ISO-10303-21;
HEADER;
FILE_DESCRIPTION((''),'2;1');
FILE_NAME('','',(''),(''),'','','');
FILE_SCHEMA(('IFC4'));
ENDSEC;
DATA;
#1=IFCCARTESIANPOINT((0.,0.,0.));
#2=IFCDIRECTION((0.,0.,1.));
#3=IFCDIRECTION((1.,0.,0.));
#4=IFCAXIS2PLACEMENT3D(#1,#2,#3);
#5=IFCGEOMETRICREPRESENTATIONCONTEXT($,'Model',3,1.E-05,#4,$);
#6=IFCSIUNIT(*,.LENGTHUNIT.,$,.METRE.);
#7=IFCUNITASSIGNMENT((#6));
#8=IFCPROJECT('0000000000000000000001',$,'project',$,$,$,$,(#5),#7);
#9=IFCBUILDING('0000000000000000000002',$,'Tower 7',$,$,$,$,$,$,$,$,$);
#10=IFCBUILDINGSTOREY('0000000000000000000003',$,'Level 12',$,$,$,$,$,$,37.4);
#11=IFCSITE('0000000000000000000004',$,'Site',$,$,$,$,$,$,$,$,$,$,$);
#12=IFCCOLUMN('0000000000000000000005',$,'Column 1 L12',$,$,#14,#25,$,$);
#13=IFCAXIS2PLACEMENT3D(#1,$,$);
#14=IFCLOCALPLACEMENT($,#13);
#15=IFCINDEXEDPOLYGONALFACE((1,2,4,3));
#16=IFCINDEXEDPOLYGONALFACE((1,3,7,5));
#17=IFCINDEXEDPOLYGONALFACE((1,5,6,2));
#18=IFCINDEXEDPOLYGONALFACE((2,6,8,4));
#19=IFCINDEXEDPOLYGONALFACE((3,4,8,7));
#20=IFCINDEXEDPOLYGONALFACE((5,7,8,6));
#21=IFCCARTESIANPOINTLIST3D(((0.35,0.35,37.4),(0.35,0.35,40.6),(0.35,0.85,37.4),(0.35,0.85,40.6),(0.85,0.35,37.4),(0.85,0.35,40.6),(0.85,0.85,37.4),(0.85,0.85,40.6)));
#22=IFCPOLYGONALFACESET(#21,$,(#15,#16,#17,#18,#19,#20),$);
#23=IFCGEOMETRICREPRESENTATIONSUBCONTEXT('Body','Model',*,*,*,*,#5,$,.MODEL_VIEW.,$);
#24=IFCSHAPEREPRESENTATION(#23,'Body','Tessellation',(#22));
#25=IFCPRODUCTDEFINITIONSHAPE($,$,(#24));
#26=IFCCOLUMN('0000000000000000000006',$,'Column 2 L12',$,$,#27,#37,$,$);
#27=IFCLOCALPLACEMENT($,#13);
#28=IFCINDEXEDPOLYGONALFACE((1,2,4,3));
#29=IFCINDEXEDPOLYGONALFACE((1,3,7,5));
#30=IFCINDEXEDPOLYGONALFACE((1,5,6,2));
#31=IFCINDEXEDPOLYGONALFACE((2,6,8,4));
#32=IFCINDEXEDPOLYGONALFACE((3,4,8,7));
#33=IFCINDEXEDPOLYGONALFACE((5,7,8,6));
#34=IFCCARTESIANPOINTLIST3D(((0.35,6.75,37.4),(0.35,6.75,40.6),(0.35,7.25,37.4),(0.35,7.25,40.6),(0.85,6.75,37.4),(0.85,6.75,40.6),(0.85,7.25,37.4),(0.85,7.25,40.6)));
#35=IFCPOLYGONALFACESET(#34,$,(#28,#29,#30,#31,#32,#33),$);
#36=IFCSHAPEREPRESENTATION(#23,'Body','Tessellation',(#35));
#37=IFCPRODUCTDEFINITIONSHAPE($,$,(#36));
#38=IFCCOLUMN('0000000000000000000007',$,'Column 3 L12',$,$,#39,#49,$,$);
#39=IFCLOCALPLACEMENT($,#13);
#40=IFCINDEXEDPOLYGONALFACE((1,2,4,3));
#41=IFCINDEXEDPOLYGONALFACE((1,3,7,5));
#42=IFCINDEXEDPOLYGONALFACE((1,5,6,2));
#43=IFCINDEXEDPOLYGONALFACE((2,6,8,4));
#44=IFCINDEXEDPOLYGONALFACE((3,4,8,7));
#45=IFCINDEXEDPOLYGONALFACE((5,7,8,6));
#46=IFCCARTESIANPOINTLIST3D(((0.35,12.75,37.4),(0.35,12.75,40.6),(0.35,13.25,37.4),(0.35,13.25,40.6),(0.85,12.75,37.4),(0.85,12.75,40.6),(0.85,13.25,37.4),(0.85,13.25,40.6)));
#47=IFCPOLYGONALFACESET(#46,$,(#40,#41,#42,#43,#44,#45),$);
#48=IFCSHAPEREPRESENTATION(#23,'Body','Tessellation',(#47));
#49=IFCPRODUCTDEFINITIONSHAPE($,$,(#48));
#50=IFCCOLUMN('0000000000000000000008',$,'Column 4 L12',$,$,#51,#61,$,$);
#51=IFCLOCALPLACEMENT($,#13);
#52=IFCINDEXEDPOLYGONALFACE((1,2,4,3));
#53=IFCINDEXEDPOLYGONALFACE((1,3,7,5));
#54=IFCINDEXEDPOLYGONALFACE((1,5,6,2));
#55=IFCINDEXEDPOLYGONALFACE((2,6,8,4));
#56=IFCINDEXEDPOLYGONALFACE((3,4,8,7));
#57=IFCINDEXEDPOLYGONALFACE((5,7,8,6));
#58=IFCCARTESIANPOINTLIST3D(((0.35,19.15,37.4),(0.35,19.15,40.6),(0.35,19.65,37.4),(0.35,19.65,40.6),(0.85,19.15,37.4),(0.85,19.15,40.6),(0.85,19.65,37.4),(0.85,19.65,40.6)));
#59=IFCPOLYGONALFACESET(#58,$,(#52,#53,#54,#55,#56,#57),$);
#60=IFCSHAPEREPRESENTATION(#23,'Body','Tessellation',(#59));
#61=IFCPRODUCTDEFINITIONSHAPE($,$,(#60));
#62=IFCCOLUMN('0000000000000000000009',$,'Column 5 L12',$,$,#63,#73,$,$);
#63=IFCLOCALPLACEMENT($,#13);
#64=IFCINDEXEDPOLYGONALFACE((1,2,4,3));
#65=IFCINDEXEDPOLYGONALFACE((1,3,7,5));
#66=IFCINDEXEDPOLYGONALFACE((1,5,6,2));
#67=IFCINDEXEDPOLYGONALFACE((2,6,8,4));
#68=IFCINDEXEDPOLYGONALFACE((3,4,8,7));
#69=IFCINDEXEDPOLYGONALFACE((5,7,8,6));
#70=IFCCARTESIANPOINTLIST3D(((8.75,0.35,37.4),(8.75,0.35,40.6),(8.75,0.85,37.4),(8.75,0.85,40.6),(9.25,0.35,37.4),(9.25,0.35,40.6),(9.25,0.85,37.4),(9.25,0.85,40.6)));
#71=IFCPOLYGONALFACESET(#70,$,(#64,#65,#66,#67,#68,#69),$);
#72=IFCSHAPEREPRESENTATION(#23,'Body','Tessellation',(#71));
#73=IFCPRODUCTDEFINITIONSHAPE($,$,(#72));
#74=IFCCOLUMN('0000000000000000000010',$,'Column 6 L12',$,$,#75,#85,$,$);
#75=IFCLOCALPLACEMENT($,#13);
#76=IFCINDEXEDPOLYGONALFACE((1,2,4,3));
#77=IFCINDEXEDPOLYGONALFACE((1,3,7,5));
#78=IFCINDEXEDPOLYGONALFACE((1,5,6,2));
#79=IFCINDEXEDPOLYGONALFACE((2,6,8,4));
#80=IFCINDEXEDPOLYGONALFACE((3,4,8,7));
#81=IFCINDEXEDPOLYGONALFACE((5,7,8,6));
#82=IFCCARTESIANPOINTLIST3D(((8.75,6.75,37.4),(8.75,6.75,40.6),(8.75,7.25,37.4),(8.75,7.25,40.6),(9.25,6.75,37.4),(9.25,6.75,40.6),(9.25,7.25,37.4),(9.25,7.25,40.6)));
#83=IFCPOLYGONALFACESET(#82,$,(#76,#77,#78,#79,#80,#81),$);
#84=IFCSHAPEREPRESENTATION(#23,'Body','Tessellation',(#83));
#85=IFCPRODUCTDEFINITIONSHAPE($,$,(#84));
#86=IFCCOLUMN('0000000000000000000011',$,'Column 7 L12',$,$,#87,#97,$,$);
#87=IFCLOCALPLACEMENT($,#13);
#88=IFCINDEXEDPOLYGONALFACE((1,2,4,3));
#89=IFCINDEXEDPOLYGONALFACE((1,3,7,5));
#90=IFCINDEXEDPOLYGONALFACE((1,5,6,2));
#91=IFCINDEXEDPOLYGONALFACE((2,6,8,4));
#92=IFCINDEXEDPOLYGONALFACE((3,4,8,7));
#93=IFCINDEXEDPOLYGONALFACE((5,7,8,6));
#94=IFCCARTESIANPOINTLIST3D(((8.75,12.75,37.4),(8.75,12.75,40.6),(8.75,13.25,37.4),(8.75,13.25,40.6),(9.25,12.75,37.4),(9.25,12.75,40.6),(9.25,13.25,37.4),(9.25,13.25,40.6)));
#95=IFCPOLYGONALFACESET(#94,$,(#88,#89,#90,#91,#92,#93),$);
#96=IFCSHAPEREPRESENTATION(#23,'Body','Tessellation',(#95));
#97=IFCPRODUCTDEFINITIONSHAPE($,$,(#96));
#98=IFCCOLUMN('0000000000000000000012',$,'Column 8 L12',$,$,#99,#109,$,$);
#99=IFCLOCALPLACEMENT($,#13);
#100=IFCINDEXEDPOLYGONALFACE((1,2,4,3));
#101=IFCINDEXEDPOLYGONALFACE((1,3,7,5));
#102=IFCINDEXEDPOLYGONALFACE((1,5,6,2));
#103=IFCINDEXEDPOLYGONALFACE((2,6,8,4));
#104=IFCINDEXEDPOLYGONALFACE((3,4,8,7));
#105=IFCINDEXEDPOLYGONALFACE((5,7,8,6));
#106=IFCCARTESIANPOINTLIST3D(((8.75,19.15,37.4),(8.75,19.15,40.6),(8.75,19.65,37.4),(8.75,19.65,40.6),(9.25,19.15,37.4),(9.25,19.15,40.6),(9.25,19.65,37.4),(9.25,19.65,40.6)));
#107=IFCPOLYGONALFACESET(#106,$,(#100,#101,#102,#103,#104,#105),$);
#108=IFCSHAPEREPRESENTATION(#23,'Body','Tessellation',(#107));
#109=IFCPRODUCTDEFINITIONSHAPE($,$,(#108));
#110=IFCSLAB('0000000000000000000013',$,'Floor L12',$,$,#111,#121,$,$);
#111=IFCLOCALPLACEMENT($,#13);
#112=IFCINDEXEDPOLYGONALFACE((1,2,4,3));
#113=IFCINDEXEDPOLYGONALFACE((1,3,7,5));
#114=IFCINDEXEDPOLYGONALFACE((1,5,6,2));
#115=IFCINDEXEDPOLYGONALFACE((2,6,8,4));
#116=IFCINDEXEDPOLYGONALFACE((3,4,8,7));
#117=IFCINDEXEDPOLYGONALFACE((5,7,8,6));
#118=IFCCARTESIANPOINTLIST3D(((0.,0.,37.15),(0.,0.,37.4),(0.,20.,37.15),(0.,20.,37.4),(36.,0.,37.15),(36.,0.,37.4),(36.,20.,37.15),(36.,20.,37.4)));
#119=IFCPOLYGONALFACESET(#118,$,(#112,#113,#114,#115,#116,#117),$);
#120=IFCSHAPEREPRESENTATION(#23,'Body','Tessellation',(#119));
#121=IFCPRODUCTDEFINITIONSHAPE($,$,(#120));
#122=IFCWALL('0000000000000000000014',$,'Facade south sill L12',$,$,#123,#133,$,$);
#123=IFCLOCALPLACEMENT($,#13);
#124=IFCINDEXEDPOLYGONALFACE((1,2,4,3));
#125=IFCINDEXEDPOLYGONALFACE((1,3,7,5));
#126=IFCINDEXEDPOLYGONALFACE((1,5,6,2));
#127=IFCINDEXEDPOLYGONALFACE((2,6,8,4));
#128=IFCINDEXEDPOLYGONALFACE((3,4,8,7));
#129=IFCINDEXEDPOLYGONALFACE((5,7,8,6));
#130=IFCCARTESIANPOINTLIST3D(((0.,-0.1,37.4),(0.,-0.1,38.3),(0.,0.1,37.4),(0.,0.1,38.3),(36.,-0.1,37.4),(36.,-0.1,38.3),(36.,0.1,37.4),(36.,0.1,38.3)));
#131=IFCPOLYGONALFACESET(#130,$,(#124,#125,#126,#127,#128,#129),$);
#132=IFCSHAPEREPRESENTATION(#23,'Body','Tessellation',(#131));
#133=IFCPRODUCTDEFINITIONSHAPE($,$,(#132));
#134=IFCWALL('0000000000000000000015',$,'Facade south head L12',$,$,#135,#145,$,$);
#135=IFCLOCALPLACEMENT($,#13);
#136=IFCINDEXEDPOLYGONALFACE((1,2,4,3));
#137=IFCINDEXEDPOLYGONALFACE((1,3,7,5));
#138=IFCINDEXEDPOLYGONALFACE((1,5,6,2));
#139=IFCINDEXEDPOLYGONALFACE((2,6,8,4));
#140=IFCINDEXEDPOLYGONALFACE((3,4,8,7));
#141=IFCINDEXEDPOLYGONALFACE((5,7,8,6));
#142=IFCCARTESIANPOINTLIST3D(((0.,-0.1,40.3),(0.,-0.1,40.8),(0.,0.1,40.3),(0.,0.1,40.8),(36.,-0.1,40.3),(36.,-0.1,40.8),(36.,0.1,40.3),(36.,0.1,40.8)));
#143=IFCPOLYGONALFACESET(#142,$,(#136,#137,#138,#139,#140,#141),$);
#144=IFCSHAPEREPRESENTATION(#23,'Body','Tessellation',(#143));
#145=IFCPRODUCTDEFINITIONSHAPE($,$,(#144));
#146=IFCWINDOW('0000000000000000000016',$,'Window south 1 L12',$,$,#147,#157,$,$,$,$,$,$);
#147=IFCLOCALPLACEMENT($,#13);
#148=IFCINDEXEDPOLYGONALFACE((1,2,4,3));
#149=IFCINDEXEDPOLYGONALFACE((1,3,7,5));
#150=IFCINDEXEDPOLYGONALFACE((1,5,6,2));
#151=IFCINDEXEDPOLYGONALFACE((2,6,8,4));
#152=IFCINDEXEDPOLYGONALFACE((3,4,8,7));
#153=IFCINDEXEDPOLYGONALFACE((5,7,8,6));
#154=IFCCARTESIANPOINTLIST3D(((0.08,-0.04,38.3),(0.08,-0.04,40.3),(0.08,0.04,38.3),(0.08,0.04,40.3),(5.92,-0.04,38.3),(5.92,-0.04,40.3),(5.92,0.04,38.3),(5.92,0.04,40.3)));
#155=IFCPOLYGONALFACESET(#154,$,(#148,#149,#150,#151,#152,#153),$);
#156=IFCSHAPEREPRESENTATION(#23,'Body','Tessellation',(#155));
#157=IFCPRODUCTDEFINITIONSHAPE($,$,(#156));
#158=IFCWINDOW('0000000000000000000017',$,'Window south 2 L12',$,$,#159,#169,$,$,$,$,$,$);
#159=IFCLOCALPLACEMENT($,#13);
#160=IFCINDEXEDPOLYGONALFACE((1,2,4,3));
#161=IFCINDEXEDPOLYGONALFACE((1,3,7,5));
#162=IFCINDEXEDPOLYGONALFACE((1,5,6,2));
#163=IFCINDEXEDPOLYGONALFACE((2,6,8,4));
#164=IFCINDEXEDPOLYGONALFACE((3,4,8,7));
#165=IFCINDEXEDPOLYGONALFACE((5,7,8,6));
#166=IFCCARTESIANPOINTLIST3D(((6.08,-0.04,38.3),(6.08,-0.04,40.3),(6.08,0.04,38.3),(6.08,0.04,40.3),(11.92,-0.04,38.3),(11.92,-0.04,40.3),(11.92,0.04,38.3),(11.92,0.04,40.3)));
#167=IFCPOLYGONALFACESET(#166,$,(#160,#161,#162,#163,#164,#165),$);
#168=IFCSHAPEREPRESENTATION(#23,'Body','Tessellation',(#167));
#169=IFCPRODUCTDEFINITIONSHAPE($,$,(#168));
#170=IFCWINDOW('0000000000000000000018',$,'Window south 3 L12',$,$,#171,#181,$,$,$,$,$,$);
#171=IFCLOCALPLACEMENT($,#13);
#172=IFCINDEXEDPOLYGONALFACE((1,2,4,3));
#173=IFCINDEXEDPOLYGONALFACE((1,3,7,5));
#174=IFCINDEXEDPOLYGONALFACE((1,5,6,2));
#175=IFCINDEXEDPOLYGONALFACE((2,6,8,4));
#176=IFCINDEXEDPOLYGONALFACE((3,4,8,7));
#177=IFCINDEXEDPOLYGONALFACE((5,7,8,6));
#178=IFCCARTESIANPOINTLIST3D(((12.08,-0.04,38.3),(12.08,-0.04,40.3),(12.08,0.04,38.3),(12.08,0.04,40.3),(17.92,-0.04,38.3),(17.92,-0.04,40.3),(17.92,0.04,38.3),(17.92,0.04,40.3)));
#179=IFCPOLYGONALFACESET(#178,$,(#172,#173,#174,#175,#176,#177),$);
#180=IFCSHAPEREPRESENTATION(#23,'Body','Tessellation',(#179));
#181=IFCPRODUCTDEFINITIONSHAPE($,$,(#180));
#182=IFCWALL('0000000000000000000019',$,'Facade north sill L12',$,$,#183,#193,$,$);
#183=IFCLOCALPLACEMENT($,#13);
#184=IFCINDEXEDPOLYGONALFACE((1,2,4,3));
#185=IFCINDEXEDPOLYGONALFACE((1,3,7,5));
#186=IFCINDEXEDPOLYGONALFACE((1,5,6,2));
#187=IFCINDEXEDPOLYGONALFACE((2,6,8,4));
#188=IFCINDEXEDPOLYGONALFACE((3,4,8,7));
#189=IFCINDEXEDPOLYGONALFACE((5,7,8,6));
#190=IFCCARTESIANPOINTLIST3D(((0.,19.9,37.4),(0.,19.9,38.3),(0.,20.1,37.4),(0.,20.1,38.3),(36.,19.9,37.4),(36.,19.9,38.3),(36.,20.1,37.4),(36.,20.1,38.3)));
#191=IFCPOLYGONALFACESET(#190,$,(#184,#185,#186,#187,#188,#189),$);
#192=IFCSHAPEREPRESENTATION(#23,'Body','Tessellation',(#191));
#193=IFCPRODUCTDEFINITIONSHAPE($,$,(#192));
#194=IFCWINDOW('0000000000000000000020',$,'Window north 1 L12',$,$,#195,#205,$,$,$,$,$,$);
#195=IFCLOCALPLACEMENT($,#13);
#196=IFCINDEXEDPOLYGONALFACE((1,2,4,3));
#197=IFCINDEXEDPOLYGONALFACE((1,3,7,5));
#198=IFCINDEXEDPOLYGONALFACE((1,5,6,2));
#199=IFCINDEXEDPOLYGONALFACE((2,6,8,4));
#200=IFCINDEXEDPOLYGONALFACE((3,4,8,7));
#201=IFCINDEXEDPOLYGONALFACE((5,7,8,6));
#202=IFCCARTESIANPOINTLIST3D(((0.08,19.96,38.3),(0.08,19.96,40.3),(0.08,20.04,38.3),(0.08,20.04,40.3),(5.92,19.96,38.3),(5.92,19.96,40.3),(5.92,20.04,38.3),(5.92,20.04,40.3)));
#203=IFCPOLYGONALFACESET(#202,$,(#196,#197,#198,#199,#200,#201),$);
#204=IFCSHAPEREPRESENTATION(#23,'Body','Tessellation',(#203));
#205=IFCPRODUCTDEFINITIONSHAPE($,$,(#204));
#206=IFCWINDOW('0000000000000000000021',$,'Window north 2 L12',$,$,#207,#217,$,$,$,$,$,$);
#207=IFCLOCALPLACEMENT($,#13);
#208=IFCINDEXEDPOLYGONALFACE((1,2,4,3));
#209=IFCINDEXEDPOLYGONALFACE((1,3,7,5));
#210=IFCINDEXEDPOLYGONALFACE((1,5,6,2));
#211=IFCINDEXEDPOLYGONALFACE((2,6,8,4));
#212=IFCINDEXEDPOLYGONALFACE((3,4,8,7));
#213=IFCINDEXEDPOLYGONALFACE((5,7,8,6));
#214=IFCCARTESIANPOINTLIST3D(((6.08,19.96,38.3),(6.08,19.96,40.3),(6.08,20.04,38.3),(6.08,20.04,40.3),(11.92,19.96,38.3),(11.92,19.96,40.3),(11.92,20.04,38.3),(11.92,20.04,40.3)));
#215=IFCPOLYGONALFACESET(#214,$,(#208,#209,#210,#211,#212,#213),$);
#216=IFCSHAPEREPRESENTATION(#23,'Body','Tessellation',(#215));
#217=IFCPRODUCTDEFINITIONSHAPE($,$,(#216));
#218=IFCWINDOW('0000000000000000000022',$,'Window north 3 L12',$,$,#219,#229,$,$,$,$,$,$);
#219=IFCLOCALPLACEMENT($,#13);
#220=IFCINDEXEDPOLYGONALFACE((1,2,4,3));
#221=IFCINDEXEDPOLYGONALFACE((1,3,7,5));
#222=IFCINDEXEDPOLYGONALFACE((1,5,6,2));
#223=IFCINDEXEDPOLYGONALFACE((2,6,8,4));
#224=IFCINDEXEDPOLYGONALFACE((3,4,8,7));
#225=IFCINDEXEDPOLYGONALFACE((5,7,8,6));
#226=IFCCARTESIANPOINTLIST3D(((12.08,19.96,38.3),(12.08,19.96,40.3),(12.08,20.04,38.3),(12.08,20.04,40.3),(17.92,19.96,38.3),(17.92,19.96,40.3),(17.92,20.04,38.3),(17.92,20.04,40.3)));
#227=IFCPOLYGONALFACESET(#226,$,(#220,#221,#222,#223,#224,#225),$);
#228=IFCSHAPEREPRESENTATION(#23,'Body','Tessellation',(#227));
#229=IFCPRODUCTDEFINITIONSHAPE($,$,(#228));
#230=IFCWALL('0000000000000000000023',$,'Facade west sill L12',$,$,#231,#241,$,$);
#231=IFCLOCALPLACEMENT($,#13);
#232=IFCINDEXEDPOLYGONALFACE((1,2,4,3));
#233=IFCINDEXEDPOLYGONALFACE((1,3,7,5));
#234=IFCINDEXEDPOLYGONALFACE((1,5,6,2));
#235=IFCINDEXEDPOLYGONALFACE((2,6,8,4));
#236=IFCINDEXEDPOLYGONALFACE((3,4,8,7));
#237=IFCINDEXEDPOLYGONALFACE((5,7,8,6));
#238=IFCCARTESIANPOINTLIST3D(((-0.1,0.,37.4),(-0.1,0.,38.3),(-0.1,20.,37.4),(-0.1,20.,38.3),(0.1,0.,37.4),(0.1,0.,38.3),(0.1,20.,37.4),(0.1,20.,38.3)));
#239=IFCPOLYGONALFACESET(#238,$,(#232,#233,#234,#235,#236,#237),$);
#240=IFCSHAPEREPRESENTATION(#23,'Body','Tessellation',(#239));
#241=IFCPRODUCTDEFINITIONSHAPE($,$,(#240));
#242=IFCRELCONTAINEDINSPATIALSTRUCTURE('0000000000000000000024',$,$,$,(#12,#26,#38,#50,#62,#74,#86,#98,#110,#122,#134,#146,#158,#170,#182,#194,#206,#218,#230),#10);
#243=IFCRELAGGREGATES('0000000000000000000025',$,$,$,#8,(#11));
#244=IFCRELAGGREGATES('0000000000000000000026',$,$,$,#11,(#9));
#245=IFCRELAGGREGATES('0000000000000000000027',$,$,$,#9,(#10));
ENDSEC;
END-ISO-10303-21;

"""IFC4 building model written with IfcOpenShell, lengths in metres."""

from ifc_helpers import new_model, si_unit, frame, origin, origin_with_axes, origin_2d, place, context, subcontext, project, spatial, rectangle, extrude, element, save


model = new_model("IFC4")

# Units and contexts
model_context = context("Model", 3, precision=1e-05, world=origin_with_axes())
body_context = subcontext(model_context, "Body", "Model", "MODEL_VIEW")
ifc_project = project(units=[si_unit("LENGTHUNIT", "METRE")], contexts=[model_context])

# Site, building, storey
site = spatial("IfcSite", under=ifc_project, Name="Site")
building = spatial("IfcBuilding", under=site, Name="Tower 7")
storey = spatial("IfcBuildingStorey", under=building, Name="Level 12", Elevation=37.4)

# Columns
for number, where, z_axis, x_axis, name in (
    (1, (0.6, 0.6, 37.4), (0.0, 0.0, 1.0), (1.0, 0.0, 0.0), "Column 1 L12"),
    (2, (0.6, 7.0, 37.4), (0.0, 0.0, 1.0), (1.0, 0.0, 0.0), "Column 2 L12"),
    (3, (0.6, 13.0, 37.4), (0.0, 0.0, 1.0), (1.0, 0.0, 0.0), "Column 3 L12"),
    (4, (0.6, 19.4, 37.4), (0.0, 0.0, 1.0), (1.0, 0.0, 0.0), "Column 4 L12"),
    (5, (9.0, 0.6, 37.4), (0.0, 0.0, 1.0), (1.0, 0.0, 0.0), "Column 5 L12"),
    (6, (9.0, 7.0, 37.4), (0.0, 0.0, 1.0), (1.0, 0.0, 0.0), "Column 6 L12"),
    (7, (9.0, 13.0, 37.4), (0.0, 0.0, 1.0), (1.0, 0.0, 0.0), "Column 7 L12"),
    (8, (9.0, 19.4, 37.4), (0.0, 0.0, 1.0), (1.0, 0.0, 0.0), "Column 8 L12"),
):
    element("IfcColumn", number, at=place(None, frame(where, z_axis=z_axis, x_axis=x_axis)), inside=storey, Name=name, context=body_context, shape_type="SweptSolid", body=[
        extrude(rectangle(XDim=0.5, YDim=0.5, at=origin_2d()), origin(), (0.0, 0.0, 1.0), 3.2),
    ])

# Slab
slab_placement = place(None, frame((18.0, 10.0, 37.15), z_axis=(0.0, 0.0, 1.0), x_axis=(1.0, 0.0, 0.0)))
element("IfcSlab", 9, at=slab_placement, inside=storey, Name="Floor L12", context=body_context, shape_type="SweptSolid", body=[
    extrude(rectangle(XDim=36.0, YDim=20.0, at=origin_2d()), origin(), (0.0, 0.0, 1.0), 0.25),
])

# Walls
wall_1_placement = place(None, frame((18.0, 0.0, 37.4), z_axis=(0.0, 0.0, 1.0), x_axis=(1.0, 0.0, 0.0)))
element("IfcWall", 10, at=wall_1_placement, inside=storey, Name="Facade south sill L12", context=body_context, shape_type="SweptSolid", body=[
    extrude(rectangle(XDim=36.0, YDim=0.2, at=origin_2d()), origin(), (0.0, 0.0, 1.0), 0.9),
])
wall_2_placement = place(None, frame((18.0, 0.0, 40.3), z_axis=(0.0, 0.0, 1.0), x_axis=(1.0, 0.0, 0.0)))
element("IfcWall", 11, at=wall_2_placement, inside=storey, Name="Facade south head L12", context=body_context, shape_type="SweptSolid", body=[
    extrude(rectangle(XDim=36.0, YDim=0.2, at=origin_2d()), origin(), (0.0, 0.0, 1.0), 0.5),
])

# Windows
for number, where, z_axis, x_axis, name in (
    (12, (3.0, 0.0, 38.3), (0.0, 0.0, 1.0), (1.0, 0.0, 0.0), "Window south 1 L12"),
    (13, (9.0, 0.0, 38.3), (0.0, 0.0, 1.0), (1.0, 0.0, 0.0), "Window south 2 L12"),
):
    element("IfcWindow", number, at=place(None, frame(where, z_axis=z_axis, x_axis=x_axis)), inside=storey, Name=name, context=body_context, shape_type="SweptSolid", body=[
        extrude(rectangle(XDim=5.84, YDim=0.08, at=origin_2d()), origin(), (0.0, 0.0, 1.0), 2.0),
    ])
window_1_placement = place(None, frame((15.0, 0.0, 38.3), z_axis=(0.0, 0.0, 1.0), x_axis=(1.0, 0.0, 0.0)))
element("IfcWindow", 14, at=window_1_placement, inside=storey, Name="Window south 3 L12", context=body_context, shape_type="SweptSolid", body=[
    extrude(rectangle(XDim=5.84, YDim=0.08, at=origin_2d()), origin(), (0.0, 0.0, 1.0), 2.0),
])

# Wall
wall_3_placement = place(None, frame((18.0, 20.0, 37.4), z_axis=(0.0, 0.0, 1.0), x_axis=(1.0, 0.0, 0.0)))
element("IfcWall", 15, at=wall_3_placement, inside=storey, Name="Facade north sill L12", context=body_context, shape_type="SweptSolid", body=[
    extrude(rectangle(XDim=36.0, YDim=0.2, at=origin_2d()), origin(), (0.0, 0.0, 1.0), 0.9),
])

# Windows
for number, where, z_axis, x_axis, name in (
    (16, (3.0, 20.0, 38.3), (0.0, 0.0, 1.0), (1.0, 0.0, 0.0), "Window north 1 L12"),
    (17, (9.0, 20.0, 38.3), (0.0, 0.0, 1.0), (1.0, 0.0, 0.0), "Window north 2 L12"),
):
    element("IfcWindow", number, at=place(None, frame(where, z_axis=z_axis, x_axis=x_axis)), inside=storey, Name=name, context=body_context, shape_type="SweptSolid", body=[
        extrude(rectangle(XDim=5.84, YDim=0.08, at=origin_2d()), origin(), (0.0, 0.0, 1.0), 2.0),
    ])
window_2_placement = place(None, frame((15.0, 20.0, 38.3), z_axis=(0.0, 0.0, 1.0), x_axis=(1.0, 0.0, 0.0)))
element("IfcWindow", 18, at=window_2_placement, inside=storey, Name="Window north 3 L12", context=body_context, shape_type="SweptSolid", body=[
    extrude(rectangle(XDim=5.84, YDim=0.08, at=origin_2d()), origin(), (0.0, 0.0, 1.0), 2.0),
])

# Wall
wall_4_placement = place(None, frame((0.0, 10.0, 37.4), z_axis=(0.0, 0.0, 1.0), x_axis=(1.0, 0.0, 0.0)))
element("IfcWall", 19, at=wall_4_placement, inside=storey, Name="Facade west sill L12", context=body_context, shape_type="SweptSolid", body=[
    extrude(rectangle(XDim=0.2, YDim=20.0, at=origin_2d()), origin(), (0.0, 0.0, 1.0), 0.9),
])

save(model, "model.ifc")
